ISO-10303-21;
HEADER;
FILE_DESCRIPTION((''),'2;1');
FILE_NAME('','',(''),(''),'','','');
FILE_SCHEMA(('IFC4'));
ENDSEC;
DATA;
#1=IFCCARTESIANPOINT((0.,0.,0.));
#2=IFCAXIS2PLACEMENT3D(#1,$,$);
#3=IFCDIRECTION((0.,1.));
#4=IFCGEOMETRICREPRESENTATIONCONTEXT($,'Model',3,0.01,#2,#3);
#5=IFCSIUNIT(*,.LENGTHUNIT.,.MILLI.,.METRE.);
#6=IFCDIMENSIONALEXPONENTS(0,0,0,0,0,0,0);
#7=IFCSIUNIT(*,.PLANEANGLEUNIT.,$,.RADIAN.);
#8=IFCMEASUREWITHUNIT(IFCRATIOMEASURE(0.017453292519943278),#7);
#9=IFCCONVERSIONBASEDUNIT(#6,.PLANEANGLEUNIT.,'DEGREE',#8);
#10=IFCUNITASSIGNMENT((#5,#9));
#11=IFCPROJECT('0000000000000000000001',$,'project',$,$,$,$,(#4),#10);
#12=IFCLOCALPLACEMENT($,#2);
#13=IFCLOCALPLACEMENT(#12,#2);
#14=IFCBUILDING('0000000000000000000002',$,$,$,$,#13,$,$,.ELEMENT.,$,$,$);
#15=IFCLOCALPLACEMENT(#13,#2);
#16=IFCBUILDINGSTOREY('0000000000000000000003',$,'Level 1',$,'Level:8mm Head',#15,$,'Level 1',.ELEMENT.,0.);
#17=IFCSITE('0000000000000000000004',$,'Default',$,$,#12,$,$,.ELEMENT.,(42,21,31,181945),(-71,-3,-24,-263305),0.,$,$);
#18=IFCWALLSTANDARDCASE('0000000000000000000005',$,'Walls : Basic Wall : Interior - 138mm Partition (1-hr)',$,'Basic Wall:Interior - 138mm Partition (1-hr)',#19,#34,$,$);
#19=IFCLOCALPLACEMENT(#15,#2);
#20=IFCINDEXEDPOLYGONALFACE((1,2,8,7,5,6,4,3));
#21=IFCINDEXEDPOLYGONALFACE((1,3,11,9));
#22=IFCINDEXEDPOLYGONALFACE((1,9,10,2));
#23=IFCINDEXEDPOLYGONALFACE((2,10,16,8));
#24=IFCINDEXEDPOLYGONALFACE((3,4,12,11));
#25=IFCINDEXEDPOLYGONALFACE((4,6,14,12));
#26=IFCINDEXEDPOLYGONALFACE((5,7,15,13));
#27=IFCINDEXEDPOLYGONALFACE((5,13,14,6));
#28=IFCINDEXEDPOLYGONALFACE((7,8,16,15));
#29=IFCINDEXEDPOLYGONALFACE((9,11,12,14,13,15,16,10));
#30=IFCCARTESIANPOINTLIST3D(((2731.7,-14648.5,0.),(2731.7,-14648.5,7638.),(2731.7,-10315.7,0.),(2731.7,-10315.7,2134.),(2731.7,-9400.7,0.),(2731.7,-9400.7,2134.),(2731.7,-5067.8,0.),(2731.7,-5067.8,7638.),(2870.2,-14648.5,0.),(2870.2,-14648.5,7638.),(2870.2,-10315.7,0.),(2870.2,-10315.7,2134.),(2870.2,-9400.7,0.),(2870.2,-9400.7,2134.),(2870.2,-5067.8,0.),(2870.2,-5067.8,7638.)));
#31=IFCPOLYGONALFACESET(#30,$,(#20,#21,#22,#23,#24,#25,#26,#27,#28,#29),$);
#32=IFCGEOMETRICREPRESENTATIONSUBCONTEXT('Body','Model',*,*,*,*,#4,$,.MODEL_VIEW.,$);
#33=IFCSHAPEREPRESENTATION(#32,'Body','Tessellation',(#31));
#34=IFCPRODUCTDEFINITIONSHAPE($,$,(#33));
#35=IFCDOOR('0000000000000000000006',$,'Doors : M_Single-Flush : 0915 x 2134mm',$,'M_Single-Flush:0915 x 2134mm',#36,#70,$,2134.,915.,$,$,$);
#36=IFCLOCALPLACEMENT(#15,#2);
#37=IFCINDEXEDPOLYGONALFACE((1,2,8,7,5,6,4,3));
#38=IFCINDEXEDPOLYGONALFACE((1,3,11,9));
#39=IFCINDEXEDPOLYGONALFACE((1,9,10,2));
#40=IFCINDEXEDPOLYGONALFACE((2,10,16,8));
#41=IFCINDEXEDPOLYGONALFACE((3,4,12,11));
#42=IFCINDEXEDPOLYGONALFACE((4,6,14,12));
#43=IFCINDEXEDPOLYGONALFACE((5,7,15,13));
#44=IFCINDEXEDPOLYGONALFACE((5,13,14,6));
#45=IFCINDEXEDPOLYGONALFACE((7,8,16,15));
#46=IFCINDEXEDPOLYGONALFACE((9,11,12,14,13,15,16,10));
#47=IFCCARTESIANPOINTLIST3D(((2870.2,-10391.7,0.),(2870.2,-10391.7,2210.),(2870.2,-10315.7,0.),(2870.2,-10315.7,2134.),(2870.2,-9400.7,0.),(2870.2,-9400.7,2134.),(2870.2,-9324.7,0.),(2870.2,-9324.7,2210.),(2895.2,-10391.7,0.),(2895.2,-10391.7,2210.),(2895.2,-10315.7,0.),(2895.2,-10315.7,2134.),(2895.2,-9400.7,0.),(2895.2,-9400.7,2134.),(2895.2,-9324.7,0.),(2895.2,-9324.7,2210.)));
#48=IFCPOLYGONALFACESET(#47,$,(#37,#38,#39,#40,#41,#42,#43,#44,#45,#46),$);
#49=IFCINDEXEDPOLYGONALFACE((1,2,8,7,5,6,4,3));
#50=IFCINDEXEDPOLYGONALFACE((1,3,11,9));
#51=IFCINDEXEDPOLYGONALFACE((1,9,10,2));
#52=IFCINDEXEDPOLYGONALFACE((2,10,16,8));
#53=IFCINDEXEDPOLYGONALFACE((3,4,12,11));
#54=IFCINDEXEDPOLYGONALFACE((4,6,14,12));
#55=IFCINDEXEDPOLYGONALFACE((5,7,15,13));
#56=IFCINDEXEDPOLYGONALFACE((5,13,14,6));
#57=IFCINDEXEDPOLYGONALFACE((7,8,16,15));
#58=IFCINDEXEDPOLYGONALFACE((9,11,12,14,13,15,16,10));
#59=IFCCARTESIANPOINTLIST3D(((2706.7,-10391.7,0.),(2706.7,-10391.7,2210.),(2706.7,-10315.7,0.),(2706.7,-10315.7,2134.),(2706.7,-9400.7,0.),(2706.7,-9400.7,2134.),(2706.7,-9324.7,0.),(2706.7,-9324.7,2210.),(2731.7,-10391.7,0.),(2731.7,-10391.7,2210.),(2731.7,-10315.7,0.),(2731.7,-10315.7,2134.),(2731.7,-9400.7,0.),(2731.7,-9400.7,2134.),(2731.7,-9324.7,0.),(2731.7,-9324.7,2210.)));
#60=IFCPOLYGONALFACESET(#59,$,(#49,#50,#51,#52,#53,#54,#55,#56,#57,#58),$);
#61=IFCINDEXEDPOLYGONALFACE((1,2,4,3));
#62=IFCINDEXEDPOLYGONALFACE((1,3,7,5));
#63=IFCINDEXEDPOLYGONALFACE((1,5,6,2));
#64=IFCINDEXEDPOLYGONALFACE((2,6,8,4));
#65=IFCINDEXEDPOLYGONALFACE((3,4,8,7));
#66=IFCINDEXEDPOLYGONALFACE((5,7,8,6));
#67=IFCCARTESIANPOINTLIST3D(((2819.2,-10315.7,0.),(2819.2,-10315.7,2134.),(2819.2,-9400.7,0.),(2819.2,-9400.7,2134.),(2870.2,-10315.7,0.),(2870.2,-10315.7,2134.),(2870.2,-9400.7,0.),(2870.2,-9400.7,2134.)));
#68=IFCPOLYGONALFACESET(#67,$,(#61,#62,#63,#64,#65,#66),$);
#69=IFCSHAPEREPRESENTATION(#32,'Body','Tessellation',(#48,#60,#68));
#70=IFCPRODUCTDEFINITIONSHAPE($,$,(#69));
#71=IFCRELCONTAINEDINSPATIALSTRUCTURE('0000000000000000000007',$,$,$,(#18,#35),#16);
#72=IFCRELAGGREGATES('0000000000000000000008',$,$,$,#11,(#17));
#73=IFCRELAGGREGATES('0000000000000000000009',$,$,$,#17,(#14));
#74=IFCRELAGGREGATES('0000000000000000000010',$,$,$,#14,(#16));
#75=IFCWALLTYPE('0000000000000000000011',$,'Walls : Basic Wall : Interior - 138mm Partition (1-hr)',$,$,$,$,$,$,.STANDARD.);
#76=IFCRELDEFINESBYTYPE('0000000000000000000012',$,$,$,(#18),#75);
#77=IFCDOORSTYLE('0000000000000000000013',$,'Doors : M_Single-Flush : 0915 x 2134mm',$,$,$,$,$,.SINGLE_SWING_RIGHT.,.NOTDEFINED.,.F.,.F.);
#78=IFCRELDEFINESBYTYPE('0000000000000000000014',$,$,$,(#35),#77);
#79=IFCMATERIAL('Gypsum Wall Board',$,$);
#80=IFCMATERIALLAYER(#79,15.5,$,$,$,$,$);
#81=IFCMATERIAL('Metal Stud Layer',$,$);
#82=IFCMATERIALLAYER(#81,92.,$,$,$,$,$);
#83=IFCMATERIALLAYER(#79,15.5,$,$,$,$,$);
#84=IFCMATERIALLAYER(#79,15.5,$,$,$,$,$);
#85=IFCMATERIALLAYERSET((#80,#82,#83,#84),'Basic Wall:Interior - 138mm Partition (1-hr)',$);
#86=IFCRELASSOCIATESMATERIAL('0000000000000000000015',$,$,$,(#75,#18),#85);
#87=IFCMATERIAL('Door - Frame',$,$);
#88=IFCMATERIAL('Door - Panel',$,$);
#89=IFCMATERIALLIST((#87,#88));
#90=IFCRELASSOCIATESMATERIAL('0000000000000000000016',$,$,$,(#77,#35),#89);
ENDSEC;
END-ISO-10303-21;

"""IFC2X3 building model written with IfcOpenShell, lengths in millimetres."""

from ifc_helpers import new_model, entity, si_unit, converted_unit, direction, frame, frame_2d, origin, place, context, subcontext, project, spatial, polyline, rectangle, outline, extrude, clip, bounded_halfspace, source, transform, mapped, material, material_list, layer, layer_set, layer_usage, type_object, type_shapes, element, fill, save


model = new_model("IFC2X3")

# Units and contexts
model_context = context("Model", 3, precision=0.01, world=origin(), true_north=direction((0.0, 1.0)))
body_context = subcontext(model_context, "Body", "Model", "MODEL_VIEW")
ifc_project = project(units=[si_unit("LENGTHUNIT", "METRE", prefix="MILLI"), converted_unit("PLANEANGLEUNIT", "DEGREE", entity("IfcRatioMeasure", 0.017453292519943278), si_unit("PLANEANGLEUNIT", "RADIAN"), dimensions=[0, 0, 0, 0, 0, 0, 0])], contexts=[model_context])

# Site, building, storey
site_placement = place(None, origin())
site = spatial("IfcSite", under=ifc_project, at=site_placement, Name="Default", CompositionType="ELEMENT", RefLatitude=(42, 21, 31, 181945), RefLongitude=(-71, -3, -24, -263305), RefElevation=0.0)
building_placement = place(site_placement, origin())
building = spatial("IfcBuilding", under=site, at=building_placement, CompositionType="ELEMENT")
storey_placement = place(building_placement, origin())
storey = spatial("IfcBuildingStorey", under=building, at=storey_placement, Name="Level 1", ObjectType="Level:8mm Head", LongName="Level 1", CompositionType="ELEMENT", Elevation=0.0)

# Shared definitions
ifc_material_1 = material(Name="Metal Stud Layer")
ifc_material_2 = material(Name="Gypsum Wall Board")

# Shared definitions
ifc_material_3 = material(Name="Door - Frame")
ifc_material_4 = material(Name="Door - Panel")
ifc_material_list = material_list([ifc_material_3, ifc_material_4])

# Shared definitions
ifc_layer_1 = layer(ifc_material_2, 15.5)
ifc_layer_2 = layer(ifc_material_1, 92.0)
ifc_layer_3 = layer(ifc_material_2, 15.5)
ifc_layer_4 = layer(ifc_material_2, 15.5)
ifc_layer_set_1 = layer_set([ifc_layer_1, ifc_layer_2, ifc_layer_3, ifc_layer_4], Name="Basic Wall:Interior - 138mm Partition (1-hr)")
wall_type_1 = type_object("IfcWallType", Name="Walls : Basic Wall : Interior - 138mm Partition (1-hr)", PredefinedType="STANDARD", material=ifc_layer_set_1)

# Wall, opening, door
ifc_layer_usage_1 = layer_usage(ifc_layer_set_1, "AXIS2", "NEGATIVE", 69.2)
door_style_1 = type_object("IfcDoorStyle", Name="Doors : M_Single-Flush : 0915 x 2134mm", ConstructionType="NOTDEFINED", OperationType="SINGLE_SWING_RIGHT", ParameterTakesPrecedence=False, Sizeable=False, material=ifc_material_list)
shared_shape_1 = source(origin(), body_context, "Body", "SweptSolid", [
    extrude(outline(polyline([(-533.5, -1124.0), (533.5, -1124.0), (533.5, 1086.0), (457.5, 1086.0), (457.5, -1048.0), (-457.5, -1048.0), (-457.5, 1086.0), (-533.5, 1086.0), (-533.5, -1124.0)])), frame((457.5, 138.5, 1086.0), z_axis=(0.0, 1.0, 0.0), x_axis=(1.0, 0.0, 0.0)), (0.0, 0.0, 1.0), 25.0),
    extrude(outline(polyline([(-1124.0, -533.5), (1086.0, -533.5), (1086.0, -457.5), (-1048.0, -457.5), (-1048.0, 457.5), (1086.0, 457.5), (1086.0, 533.5), (-1124.0, 533.5), (-1124.0, -533.5)])), frame((457.5, -25.0, 1086.0), z_axis=(0.0, 1.0, 0.0), x_axis=(0.0, 0.0, -1.0)), (0.0, 0.0, 1.0), 25.0),
    extrude(rectangle(XDim=51.0, YDim=915.0, at=frame_2d((0.0, 0.0), x_axis=(1.0, 0.0))), frame((457.5, 113.0, 0.0), z_axis=(0.0, 0.0, 1.0), x_axis=(0.0, 1.0, 0.0)), (0.0, 0.0, 1.0), 2134.0),
])
type_shapes(door_style_1, [shared_shape_1])
wall_1_placement = place(storey_placement, frame((2800.9, -5067.8, 0.0), z_axis=(0.0, 0.0, 1.0), x_axis=(0.0, -1.0, 0.0)))
wall_1 = element("IfcWallStandardCase", 1, at=wall_1_placement, inside=storey, type_object=wall_type_1, material=ifc_layer_usage_1, Name="Walls : Basic Wall : Interior - 138mm Partition (1-hr)", ObjectType="Basic Wall:Interior - 138mm Partition (1-hr)", context=body_context, shape_type="Clipping", body=[
    clip(extrude(rectangle(XDim=9580.8, YDim=138.5, at=frame_2d((4790.4, 0.0), x_axis=(-1.0, 0.0))), origin(), (0.0, 0.0, 1.0), 7638.0), bounded_halfspace(frame((0.0, -69.2, 7638.0), z_axis=(0.0, 0.0, -1.0), x_axis=(1.0, 0.0, 0.0)), True, frame((0.0, -69.2, 7638.0)), polyline([(0.0, 0.0), (2920212.6, 0.0), (2920212.6, 42214.8), (0.0, 42214.8), (0.0, 0.0)]))),
])
opening_1_placement = place(wall_1_placement, frame((4332.9, -69.3, 0.0)))
opening_1 = element("IfcOpeningElement", 2, at=opening_1_placement, cuts=wall_1, ObjectType="Opening", context=body_context, shape_type="SweptSolid", body=[
    extrude(rectangle(XDim=915.0, YDim=2134.0, at=frame_2d((1067.0, 457.5), x_axis=(0.0, 1.0))), frame((0.0, 0.0, 0.0), z_axis=(0.0, 1.0, 0.0), x_axis=(0.0, 0.0, 1.0)), (0.0, 0.0, 1.0), 138.5),
])
door_1_placement = place(opening_1_placement, origin())
door_1 = element("IfcDoor", 3, at=door_1_placement, inside=storey, type_object=door_style_1, material=ifc_material_list, Name="Doors : M_Single-Flush : 0915 x 2134mm", ObjectType="M_Single-Flush:0915 x 2134mm", OverallHeight=2134.0, OverallWidth=915.0, context=body_context, shape_type="MappedRepresentation", body=[
    mapped(shared_shape_1, transform((0.0, 0.0, 0.0), scale=1.0)),
])
fill(opening_1, door_1)

save(model, "model.ifc")
